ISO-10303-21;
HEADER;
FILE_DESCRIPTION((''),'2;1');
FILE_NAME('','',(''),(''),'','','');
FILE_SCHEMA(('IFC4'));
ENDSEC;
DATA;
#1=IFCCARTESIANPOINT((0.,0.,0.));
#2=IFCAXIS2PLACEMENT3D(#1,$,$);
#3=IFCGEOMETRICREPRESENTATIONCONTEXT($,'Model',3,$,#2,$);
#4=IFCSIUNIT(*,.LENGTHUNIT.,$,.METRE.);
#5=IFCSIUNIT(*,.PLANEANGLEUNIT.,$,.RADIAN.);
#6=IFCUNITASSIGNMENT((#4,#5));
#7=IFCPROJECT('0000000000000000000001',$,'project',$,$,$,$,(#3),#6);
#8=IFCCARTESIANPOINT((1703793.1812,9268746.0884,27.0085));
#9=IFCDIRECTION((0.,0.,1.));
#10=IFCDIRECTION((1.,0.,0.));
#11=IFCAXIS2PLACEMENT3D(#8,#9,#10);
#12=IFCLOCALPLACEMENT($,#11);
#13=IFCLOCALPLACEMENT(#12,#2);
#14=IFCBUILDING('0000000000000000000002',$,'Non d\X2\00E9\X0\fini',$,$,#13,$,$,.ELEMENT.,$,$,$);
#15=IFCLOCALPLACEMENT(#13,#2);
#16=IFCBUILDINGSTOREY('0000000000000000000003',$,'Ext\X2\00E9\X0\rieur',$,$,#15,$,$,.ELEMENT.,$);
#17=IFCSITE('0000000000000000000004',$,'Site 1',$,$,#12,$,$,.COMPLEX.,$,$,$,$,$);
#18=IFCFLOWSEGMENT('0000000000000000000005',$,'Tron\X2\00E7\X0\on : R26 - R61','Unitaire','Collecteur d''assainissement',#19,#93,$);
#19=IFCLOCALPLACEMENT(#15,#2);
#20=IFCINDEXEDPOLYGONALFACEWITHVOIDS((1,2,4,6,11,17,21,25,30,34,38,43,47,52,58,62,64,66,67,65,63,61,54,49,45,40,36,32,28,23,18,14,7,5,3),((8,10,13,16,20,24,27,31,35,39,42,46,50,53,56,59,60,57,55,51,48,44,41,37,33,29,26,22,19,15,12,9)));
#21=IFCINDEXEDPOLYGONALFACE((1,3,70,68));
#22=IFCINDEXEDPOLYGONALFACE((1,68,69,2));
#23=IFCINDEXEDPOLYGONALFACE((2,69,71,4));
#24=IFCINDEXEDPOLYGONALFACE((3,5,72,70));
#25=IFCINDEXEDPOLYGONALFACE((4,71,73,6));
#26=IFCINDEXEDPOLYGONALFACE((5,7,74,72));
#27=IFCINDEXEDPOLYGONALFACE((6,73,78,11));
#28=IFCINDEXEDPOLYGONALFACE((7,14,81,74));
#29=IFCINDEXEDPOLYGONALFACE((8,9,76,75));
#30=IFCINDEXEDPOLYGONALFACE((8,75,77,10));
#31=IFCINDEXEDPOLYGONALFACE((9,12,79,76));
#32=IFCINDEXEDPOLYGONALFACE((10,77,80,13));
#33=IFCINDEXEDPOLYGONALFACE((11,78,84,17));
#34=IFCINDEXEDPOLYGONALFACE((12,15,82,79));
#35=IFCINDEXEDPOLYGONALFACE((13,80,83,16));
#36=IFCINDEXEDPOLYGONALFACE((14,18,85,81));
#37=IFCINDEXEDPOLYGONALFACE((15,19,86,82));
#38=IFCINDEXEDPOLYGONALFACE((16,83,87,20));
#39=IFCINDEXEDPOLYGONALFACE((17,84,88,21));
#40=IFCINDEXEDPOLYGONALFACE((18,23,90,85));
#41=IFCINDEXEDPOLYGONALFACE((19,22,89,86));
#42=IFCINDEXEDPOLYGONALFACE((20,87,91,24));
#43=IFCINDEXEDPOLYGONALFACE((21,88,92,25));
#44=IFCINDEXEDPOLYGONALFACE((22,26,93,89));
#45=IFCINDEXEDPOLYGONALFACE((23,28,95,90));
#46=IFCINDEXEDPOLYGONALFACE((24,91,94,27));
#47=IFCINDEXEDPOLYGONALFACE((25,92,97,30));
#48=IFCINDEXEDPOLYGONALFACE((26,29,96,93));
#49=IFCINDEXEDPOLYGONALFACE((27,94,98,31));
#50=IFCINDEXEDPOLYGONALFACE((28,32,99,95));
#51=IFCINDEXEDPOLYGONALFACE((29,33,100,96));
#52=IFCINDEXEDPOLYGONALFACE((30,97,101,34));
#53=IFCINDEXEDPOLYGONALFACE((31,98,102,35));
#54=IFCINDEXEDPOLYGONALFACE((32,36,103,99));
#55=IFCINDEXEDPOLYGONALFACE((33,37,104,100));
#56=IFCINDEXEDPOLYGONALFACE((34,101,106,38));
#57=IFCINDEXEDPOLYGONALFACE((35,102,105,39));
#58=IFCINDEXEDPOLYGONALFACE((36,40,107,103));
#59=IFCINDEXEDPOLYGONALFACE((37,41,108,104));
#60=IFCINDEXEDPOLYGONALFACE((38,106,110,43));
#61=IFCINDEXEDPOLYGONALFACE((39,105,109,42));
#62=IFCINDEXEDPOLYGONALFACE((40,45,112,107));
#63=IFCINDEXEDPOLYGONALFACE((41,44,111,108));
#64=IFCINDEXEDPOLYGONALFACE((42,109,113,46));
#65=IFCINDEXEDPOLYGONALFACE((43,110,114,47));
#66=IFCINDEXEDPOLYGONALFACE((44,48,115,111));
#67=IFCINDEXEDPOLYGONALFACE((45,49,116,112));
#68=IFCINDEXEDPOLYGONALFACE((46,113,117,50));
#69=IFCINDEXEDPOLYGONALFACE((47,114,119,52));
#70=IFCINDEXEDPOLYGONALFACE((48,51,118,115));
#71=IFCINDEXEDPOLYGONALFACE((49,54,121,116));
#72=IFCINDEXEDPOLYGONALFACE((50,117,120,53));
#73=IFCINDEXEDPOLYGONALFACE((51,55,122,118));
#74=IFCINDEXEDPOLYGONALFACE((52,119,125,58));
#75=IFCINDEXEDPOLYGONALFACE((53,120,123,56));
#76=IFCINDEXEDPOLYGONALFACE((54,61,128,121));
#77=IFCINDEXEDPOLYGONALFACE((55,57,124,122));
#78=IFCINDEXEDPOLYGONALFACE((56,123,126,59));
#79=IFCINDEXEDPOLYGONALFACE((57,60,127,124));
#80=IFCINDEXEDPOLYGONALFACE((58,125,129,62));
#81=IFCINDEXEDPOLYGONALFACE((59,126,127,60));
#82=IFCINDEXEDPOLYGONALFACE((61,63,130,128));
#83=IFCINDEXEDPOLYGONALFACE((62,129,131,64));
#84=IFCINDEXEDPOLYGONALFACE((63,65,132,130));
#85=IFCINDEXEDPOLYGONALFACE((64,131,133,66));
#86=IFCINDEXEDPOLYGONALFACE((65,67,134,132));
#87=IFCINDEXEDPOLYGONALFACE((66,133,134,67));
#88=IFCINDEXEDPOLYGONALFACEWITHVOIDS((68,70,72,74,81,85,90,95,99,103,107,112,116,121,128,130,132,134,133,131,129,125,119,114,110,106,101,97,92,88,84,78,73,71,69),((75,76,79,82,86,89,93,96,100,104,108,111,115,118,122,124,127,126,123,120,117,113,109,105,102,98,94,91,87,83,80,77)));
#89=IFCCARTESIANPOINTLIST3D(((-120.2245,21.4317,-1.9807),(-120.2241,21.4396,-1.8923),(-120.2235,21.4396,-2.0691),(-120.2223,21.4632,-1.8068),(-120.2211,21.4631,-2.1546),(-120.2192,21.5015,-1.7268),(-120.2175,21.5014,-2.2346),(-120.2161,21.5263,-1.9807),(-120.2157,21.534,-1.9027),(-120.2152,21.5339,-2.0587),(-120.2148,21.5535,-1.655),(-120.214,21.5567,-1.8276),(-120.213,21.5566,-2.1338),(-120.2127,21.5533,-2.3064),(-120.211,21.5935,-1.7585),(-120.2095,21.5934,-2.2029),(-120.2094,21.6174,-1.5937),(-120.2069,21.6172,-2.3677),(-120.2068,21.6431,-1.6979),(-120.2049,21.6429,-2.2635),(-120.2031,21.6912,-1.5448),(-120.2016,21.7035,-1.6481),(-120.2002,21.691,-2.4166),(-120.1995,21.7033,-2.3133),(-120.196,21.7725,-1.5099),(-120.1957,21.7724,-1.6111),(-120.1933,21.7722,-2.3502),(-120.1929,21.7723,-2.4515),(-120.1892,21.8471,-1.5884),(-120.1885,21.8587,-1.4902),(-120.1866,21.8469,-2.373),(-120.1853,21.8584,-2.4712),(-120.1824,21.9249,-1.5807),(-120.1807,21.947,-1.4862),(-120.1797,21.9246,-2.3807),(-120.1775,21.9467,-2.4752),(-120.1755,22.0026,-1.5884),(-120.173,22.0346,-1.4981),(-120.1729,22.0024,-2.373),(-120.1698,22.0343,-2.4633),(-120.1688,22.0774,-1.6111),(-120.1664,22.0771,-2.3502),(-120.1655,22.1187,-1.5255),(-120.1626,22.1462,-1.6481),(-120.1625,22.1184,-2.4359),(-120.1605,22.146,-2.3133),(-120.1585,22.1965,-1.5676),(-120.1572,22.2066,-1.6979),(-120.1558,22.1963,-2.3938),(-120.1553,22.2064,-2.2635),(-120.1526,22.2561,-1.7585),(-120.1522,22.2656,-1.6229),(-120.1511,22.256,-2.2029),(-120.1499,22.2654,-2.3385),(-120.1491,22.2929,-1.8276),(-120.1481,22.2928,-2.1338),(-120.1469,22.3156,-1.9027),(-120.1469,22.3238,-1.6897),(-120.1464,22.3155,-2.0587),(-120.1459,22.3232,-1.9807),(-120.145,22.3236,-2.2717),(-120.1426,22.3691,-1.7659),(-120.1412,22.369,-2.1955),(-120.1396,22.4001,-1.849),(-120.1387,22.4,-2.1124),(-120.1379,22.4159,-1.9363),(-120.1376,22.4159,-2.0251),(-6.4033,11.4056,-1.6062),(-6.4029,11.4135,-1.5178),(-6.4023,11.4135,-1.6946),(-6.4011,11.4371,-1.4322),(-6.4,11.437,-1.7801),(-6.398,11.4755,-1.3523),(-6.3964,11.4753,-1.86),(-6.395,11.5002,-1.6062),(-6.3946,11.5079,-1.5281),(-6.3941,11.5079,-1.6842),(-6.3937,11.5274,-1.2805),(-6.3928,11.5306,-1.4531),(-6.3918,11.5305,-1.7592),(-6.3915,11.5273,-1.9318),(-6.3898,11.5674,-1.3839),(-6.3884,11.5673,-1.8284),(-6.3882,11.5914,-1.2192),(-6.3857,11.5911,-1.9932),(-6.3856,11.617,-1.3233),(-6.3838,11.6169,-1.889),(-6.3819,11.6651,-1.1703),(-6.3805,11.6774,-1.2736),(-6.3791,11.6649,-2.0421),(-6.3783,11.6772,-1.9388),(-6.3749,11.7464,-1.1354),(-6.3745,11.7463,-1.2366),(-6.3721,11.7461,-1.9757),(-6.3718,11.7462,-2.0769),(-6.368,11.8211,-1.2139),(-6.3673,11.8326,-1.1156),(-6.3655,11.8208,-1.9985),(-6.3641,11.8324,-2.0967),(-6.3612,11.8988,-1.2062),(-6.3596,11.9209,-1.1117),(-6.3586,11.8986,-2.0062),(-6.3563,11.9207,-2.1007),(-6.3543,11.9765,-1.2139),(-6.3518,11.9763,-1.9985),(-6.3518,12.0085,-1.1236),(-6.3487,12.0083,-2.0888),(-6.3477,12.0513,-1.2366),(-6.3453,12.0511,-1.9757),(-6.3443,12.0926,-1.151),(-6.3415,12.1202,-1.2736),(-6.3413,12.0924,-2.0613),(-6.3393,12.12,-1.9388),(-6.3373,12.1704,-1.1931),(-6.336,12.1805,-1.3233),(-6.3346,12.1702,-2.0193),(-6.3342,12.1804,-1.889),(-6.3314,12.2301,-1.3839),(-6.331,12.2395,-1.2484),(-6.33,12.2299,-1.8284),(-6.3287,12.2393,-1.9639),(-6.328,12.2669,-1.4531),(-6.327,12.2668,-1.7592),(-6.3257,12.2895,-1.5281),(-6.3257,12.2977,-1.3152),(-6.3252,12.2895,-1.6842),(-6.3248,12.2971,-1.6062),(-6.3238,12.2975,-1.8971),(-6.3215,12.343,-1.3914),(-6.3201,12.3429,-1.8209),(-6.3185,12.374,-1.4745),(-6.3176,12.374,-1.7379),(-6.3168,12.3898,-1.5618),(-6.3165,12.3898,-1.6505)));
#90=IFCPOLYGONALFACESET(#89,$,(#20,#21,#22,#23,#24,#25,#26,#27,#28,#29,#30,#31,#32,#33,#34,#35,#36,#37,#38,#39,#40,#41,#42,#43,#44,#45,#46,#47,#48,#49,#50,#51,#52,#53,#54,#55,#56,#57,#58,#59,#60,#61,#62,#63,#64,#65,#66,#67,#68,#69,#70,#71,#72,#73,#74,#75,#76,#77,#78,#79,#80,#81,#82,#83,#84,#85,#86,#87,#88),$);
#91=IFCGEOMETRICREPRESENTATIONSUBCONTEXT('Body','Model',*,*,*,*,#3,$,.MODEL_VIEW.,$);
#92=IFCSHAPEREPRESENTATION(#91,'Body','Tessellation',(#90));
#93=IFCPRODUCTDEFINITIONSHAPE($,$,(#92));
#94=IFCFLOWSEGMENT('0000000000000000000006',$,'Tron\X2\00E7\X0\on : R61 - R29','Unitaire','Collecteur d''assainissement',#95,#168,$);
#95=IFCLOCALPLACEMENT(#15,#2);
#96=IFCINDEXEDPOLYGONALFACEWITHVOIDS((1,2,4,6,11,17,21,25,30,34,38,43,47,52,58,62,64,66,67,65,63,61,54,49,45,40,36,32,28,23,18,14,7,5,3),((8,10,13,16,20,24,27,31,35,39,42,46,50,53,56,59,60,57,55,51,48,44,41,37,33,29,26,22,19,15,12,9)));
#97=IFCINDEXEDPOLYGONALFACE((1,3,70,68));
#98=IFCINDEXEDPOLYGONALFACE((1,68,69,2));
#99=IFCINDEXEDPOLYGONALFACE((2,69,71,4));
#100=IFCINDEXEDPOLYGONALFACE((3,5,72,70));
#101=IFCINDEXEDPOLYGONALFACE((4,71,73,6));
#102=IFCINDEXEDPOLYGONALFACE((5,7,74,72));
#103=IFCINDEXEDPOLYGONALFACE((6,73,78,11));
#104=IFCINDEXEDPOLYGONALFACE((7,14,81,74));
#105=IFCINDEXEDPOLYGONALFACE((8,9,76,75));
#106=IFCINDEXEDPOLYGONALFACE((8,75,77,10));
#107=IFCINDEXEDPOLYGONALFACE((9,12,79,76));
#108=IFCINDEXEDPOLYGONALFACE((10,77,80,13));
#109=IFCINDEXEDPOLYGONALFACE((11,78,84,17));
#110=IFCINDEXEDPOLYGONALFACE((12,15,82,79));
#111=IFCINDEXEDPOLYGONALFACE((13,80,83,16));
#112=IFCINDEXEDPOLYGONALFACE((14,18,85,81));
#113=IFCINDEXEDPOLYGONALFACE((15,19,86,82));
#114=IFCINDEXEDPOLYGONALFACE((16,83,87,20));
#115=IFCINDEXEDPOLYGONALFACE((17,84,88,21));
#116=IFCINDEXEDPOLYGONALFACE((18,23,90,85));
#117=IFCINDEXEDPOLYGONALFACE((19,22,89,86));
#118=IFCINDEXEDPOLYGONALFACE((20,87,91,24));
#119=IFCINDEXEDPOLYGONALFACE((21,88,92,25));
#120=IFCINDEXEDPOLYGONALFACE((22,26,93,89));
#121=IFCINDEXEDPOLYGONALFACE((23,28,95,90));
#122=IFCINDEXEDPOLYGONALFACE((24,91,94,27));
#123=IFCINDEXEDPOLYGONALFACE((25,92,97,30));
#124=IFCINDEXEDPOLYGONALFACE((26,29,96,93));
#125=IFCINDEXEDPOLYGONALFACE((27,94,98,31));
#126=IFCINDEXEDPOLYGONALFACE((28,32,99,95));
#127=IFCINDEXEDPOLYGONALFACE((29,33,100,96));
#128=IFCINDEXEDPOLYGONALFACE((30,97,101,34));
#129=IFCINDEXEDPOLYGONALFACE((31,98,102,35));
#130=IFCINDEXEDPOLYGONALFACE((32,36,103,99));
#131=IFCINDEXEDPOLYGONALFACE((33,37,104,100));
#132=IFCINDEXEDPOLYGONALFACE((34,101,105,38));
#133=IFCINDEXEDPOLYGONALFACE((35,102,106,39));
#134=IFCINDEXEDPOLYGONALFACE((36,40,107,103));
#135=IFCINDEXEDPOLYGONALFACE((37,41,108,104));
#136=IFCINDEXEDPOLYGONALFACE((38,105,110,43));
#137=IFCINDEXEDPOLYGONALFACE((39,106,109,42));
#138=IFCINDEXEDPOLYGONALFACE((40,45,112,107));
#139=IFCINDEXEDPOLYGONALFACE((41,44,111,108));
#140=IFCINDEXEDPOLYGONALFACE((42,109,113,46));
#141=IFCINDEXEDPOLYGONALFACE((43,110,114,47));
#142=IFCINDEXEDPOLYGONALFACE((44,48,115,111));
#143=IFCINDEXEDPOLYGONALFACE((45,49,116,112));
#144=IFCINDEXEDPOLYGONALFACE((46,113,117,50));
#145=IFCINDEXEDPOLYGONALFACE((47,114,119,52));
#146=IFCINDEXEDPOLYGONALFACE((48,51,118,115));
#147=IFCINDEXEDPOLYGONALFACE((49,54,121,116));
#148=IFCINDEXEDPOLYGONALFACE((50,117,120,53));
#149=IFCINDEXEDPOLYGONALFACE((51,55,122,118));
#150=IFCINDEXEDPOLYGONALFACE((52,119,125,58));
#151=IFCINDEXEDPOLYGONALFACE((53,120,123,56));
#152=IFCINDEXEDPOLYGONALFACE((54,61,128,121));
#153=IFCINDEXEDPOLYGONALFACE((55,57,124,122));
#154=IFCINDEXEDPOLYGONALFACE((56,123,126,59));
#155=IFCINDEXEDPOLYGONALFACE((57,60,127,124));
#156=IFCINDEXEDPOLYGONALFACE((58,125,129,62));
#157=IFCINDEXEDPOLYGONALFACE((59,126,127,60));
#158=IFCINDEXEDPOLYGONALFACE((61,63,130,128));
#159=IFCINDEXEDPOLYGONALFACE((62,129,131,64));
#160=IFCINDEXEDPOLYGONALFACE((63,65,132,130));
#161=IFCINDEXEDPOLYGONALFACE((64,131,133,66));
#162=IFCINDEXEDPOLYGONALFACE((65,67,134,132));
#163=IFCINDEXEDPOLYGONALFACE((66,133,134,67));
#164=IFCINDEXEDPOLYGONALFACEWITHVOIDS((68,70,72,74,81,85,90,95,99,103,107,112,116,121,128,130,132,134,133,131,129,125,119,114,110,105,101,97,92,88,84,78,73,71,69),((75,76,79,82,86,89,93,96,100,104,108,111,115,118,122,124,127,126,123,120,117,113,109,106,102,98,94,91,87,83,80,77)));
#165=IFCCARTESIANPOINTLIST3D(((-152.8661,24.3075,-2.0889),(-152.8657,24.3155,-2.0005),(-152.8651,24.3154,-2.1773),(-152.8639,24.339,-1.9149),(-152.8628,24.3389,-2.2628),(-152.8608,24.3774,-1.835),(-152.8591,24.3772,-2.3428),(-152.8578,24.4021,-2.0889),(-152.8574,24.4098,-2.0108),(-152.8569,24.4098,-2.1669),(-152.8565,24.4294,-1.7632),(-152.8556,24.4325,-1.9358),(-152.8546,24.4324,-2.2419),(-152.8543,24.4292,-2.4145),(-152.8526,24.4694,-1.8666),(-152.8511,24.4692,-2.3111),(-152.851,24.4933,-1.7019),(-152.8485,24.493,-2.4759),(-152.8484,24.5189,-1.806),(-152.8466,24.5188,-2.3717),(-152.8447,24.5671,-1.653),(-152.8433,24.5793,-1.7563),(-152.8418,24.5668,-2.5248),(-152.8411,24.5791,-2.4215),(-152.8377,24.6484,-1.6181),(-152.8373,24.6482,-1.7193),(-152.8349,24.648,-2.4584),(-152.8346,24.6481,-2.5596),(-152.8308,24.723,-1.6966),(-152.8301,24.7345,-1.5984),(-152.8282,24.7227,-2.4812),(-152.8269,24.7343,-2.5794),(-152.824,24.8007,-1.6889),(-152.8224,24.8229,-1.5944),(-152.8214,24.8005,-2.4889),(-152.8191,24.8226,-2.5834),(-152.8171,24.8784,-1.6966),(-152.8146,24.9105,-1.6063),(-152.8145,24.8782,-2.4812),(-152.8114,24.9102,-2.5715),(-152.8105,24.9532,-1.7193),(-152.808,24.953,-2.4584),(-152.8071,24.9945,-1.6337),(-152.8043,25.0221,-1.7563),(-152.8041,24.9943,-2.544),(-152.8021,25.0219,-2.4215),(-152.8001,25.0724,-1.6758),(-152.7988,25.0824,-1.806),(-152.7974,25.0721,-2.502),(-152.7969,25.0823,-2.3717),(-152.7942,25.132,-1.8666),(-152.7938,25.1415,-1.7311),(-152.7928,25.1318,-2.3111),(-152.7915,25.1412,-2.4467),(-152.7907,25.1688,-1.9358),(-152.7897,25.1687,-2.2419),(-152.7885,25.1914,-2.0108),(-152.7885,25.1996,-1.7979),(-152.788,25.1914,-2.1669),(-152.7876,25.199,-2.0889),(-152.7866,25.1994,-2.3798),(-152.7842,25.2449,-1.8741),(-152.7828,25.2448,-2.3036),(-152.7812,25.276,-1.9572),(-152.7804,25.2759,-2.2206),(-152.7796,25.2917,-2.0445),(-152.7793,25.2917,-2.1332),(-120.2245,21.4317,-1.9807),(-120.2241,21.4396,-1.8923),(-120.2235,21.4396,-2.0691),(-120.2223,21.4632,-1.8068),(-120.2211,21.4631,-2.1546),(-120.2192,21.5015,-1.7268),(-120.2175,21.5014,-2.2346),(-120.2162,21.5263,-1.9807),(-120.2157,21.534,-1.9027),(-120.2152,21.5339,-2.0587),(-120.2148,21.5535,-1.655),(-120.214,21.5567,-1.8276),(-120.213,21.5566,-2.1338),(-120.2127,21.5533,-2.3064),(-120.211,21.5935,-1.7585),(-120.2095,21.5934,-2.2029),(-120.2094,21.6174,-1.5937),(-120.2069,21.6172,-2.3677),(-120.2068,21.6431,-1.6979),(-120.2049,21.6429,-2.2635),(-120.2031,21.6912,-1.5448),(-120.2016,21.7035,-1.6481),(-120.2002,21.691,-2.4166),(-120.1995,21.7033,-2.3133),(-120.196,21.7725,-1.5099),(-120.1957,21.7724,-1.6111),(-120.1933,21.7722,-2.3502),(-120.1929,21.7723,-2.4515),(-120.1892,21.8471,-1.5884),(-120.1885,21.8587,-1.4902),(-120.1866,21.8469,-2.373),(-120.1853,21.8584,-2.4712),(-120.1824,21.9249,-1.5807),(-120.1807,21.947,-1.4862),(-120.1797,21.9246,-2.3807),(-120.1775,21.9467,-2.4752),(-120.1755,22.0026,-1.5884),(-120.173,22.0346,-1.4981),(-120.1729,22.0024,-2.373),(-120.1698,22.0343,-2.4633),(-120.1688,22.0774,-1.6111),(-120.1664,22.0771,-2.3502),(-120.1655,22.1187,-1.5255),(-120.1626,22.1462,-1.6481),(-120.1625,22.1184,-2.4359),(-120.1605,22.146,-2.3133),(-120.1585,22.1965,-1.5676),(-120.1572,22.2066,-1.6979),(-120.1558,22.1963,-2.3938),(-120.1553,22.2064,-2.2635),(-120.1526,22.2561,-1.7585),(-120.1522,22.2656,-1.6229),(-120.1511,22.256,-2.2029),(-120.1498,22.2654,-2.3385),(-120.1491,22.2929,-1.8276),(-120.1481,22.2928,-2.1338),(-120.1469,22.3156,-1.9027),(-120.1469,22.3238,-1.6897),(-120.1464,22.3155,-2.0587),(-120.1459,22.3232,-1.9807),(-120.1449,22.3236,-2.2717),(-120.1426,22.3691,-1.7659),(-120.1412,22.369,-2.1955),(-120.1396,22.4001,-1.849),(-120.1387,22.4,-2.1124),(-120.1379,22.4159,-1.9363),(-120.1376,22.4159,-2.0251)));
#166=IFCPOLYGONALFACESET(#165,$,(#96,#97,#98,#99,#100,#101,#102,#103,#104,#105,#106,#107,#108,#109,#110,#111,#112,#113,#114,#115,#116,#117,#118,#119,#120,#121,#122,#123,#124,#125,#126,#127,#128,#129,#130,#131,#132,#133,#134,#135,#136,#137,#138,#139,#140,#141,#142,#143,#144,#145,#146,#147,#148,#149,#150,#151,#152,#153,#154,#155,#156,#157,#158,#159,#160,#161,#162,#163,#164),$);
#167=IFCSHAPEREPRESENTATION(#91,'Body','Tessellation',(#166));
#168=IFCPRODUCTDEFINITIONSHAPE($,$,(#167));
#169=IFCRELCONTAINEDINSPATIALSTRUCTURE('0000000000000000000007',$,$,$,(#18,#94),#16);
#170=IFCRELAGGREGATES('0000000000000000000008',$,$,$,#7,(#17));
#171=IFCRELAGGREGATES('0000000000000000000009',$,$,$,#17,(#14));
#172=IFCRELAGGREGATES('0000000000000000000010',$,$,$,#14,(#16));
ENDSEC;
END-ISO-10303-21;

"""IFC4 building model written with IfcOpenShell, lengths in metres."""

from ifc_helpers import new_model, si_unit, frame, origin, origin_2d, place, context, subcontext, project, spatial, hollow_circle, extrude, element, save


model = new_model("IFC4")

# Units and contexts
model_context = context("Model", 3, world=origin())
body_context = subcontext(model_context, "Body", "Model", "MODEL_VIEW")
ifc_project = project(units=[si_unit("LENGTHUNIT", "METRE"), si_unit("PLANEANGLEUNIT", "RADIAN")], contexts=[model_context])

# Site, building, storey
site_placement = place(None, frame((1703793.1812, 9268746.0884, 27.0085), z_axis=(0.0, 0.0, 1.0), x_axis=(1.0, 0.0, 0.0)))
site = spatial("IfcSite", under=ifc_project, at=site_placement, Name="Site 1", CompositionType="COMPLEX")
building_placement = place(site_placement, origin())
building = spatial("IfcBuilding", under=site, at=building_placement, Name="Non défini", CompositionType="ELEMENT")
storey_placement = place(building_placement, origin())
storey = spatial("IfcBuildingStorey", under=building, at=storey_placement, Name="Extérieur", CompositionType="ELEMENT")

# Flow segments
flow_segment_1_placement = place(storey_placement, origin())
element("IfcFlowSegment", 1, at=flow_segment_1_placement, inside=storey, Name="Tronçon : R26 - R61", Description="Unitaire", ObjectType="Collecteur d'assainissement", context=body_context, shape_type="SweptSolid", body=[
    extrude(hollow_circle(Radius=0.495, WallThickness=0.095, at=origin_2d()), frame((-6.3599, 11.8987, -1.6062), z_axis=(-0.996137, 0.087746, -0.003278), x_axis=(-0.087746, -0.996143, 0.0)), (0.0, 0.0, 1.0), 114.2625),
])
flow_segment_2_placement = place(storey_placement, origin())
element("IfcFlowSegment", 2, at=flow_segment_2_placement, inside=storey, Name="Tronçon : R61 - R29", Description="Unitaire", ObjectType="Collecteur d'assainissement", context=body_context, shape_type="SweptSolid", body=[
    extrude(hollow_circle(Radius=0.495, WallThickness=0.095, at=origin_2d()), frame((-120.181, 21.9248, -1.9807), z_axis=(-0.996136, 0.087763, -0.003301), x_axis=(-0.087763, -0.996141, 0.0)), (0.0, 0.0, 1.0), 32.7683),
])

save(model, "model.ifc")
